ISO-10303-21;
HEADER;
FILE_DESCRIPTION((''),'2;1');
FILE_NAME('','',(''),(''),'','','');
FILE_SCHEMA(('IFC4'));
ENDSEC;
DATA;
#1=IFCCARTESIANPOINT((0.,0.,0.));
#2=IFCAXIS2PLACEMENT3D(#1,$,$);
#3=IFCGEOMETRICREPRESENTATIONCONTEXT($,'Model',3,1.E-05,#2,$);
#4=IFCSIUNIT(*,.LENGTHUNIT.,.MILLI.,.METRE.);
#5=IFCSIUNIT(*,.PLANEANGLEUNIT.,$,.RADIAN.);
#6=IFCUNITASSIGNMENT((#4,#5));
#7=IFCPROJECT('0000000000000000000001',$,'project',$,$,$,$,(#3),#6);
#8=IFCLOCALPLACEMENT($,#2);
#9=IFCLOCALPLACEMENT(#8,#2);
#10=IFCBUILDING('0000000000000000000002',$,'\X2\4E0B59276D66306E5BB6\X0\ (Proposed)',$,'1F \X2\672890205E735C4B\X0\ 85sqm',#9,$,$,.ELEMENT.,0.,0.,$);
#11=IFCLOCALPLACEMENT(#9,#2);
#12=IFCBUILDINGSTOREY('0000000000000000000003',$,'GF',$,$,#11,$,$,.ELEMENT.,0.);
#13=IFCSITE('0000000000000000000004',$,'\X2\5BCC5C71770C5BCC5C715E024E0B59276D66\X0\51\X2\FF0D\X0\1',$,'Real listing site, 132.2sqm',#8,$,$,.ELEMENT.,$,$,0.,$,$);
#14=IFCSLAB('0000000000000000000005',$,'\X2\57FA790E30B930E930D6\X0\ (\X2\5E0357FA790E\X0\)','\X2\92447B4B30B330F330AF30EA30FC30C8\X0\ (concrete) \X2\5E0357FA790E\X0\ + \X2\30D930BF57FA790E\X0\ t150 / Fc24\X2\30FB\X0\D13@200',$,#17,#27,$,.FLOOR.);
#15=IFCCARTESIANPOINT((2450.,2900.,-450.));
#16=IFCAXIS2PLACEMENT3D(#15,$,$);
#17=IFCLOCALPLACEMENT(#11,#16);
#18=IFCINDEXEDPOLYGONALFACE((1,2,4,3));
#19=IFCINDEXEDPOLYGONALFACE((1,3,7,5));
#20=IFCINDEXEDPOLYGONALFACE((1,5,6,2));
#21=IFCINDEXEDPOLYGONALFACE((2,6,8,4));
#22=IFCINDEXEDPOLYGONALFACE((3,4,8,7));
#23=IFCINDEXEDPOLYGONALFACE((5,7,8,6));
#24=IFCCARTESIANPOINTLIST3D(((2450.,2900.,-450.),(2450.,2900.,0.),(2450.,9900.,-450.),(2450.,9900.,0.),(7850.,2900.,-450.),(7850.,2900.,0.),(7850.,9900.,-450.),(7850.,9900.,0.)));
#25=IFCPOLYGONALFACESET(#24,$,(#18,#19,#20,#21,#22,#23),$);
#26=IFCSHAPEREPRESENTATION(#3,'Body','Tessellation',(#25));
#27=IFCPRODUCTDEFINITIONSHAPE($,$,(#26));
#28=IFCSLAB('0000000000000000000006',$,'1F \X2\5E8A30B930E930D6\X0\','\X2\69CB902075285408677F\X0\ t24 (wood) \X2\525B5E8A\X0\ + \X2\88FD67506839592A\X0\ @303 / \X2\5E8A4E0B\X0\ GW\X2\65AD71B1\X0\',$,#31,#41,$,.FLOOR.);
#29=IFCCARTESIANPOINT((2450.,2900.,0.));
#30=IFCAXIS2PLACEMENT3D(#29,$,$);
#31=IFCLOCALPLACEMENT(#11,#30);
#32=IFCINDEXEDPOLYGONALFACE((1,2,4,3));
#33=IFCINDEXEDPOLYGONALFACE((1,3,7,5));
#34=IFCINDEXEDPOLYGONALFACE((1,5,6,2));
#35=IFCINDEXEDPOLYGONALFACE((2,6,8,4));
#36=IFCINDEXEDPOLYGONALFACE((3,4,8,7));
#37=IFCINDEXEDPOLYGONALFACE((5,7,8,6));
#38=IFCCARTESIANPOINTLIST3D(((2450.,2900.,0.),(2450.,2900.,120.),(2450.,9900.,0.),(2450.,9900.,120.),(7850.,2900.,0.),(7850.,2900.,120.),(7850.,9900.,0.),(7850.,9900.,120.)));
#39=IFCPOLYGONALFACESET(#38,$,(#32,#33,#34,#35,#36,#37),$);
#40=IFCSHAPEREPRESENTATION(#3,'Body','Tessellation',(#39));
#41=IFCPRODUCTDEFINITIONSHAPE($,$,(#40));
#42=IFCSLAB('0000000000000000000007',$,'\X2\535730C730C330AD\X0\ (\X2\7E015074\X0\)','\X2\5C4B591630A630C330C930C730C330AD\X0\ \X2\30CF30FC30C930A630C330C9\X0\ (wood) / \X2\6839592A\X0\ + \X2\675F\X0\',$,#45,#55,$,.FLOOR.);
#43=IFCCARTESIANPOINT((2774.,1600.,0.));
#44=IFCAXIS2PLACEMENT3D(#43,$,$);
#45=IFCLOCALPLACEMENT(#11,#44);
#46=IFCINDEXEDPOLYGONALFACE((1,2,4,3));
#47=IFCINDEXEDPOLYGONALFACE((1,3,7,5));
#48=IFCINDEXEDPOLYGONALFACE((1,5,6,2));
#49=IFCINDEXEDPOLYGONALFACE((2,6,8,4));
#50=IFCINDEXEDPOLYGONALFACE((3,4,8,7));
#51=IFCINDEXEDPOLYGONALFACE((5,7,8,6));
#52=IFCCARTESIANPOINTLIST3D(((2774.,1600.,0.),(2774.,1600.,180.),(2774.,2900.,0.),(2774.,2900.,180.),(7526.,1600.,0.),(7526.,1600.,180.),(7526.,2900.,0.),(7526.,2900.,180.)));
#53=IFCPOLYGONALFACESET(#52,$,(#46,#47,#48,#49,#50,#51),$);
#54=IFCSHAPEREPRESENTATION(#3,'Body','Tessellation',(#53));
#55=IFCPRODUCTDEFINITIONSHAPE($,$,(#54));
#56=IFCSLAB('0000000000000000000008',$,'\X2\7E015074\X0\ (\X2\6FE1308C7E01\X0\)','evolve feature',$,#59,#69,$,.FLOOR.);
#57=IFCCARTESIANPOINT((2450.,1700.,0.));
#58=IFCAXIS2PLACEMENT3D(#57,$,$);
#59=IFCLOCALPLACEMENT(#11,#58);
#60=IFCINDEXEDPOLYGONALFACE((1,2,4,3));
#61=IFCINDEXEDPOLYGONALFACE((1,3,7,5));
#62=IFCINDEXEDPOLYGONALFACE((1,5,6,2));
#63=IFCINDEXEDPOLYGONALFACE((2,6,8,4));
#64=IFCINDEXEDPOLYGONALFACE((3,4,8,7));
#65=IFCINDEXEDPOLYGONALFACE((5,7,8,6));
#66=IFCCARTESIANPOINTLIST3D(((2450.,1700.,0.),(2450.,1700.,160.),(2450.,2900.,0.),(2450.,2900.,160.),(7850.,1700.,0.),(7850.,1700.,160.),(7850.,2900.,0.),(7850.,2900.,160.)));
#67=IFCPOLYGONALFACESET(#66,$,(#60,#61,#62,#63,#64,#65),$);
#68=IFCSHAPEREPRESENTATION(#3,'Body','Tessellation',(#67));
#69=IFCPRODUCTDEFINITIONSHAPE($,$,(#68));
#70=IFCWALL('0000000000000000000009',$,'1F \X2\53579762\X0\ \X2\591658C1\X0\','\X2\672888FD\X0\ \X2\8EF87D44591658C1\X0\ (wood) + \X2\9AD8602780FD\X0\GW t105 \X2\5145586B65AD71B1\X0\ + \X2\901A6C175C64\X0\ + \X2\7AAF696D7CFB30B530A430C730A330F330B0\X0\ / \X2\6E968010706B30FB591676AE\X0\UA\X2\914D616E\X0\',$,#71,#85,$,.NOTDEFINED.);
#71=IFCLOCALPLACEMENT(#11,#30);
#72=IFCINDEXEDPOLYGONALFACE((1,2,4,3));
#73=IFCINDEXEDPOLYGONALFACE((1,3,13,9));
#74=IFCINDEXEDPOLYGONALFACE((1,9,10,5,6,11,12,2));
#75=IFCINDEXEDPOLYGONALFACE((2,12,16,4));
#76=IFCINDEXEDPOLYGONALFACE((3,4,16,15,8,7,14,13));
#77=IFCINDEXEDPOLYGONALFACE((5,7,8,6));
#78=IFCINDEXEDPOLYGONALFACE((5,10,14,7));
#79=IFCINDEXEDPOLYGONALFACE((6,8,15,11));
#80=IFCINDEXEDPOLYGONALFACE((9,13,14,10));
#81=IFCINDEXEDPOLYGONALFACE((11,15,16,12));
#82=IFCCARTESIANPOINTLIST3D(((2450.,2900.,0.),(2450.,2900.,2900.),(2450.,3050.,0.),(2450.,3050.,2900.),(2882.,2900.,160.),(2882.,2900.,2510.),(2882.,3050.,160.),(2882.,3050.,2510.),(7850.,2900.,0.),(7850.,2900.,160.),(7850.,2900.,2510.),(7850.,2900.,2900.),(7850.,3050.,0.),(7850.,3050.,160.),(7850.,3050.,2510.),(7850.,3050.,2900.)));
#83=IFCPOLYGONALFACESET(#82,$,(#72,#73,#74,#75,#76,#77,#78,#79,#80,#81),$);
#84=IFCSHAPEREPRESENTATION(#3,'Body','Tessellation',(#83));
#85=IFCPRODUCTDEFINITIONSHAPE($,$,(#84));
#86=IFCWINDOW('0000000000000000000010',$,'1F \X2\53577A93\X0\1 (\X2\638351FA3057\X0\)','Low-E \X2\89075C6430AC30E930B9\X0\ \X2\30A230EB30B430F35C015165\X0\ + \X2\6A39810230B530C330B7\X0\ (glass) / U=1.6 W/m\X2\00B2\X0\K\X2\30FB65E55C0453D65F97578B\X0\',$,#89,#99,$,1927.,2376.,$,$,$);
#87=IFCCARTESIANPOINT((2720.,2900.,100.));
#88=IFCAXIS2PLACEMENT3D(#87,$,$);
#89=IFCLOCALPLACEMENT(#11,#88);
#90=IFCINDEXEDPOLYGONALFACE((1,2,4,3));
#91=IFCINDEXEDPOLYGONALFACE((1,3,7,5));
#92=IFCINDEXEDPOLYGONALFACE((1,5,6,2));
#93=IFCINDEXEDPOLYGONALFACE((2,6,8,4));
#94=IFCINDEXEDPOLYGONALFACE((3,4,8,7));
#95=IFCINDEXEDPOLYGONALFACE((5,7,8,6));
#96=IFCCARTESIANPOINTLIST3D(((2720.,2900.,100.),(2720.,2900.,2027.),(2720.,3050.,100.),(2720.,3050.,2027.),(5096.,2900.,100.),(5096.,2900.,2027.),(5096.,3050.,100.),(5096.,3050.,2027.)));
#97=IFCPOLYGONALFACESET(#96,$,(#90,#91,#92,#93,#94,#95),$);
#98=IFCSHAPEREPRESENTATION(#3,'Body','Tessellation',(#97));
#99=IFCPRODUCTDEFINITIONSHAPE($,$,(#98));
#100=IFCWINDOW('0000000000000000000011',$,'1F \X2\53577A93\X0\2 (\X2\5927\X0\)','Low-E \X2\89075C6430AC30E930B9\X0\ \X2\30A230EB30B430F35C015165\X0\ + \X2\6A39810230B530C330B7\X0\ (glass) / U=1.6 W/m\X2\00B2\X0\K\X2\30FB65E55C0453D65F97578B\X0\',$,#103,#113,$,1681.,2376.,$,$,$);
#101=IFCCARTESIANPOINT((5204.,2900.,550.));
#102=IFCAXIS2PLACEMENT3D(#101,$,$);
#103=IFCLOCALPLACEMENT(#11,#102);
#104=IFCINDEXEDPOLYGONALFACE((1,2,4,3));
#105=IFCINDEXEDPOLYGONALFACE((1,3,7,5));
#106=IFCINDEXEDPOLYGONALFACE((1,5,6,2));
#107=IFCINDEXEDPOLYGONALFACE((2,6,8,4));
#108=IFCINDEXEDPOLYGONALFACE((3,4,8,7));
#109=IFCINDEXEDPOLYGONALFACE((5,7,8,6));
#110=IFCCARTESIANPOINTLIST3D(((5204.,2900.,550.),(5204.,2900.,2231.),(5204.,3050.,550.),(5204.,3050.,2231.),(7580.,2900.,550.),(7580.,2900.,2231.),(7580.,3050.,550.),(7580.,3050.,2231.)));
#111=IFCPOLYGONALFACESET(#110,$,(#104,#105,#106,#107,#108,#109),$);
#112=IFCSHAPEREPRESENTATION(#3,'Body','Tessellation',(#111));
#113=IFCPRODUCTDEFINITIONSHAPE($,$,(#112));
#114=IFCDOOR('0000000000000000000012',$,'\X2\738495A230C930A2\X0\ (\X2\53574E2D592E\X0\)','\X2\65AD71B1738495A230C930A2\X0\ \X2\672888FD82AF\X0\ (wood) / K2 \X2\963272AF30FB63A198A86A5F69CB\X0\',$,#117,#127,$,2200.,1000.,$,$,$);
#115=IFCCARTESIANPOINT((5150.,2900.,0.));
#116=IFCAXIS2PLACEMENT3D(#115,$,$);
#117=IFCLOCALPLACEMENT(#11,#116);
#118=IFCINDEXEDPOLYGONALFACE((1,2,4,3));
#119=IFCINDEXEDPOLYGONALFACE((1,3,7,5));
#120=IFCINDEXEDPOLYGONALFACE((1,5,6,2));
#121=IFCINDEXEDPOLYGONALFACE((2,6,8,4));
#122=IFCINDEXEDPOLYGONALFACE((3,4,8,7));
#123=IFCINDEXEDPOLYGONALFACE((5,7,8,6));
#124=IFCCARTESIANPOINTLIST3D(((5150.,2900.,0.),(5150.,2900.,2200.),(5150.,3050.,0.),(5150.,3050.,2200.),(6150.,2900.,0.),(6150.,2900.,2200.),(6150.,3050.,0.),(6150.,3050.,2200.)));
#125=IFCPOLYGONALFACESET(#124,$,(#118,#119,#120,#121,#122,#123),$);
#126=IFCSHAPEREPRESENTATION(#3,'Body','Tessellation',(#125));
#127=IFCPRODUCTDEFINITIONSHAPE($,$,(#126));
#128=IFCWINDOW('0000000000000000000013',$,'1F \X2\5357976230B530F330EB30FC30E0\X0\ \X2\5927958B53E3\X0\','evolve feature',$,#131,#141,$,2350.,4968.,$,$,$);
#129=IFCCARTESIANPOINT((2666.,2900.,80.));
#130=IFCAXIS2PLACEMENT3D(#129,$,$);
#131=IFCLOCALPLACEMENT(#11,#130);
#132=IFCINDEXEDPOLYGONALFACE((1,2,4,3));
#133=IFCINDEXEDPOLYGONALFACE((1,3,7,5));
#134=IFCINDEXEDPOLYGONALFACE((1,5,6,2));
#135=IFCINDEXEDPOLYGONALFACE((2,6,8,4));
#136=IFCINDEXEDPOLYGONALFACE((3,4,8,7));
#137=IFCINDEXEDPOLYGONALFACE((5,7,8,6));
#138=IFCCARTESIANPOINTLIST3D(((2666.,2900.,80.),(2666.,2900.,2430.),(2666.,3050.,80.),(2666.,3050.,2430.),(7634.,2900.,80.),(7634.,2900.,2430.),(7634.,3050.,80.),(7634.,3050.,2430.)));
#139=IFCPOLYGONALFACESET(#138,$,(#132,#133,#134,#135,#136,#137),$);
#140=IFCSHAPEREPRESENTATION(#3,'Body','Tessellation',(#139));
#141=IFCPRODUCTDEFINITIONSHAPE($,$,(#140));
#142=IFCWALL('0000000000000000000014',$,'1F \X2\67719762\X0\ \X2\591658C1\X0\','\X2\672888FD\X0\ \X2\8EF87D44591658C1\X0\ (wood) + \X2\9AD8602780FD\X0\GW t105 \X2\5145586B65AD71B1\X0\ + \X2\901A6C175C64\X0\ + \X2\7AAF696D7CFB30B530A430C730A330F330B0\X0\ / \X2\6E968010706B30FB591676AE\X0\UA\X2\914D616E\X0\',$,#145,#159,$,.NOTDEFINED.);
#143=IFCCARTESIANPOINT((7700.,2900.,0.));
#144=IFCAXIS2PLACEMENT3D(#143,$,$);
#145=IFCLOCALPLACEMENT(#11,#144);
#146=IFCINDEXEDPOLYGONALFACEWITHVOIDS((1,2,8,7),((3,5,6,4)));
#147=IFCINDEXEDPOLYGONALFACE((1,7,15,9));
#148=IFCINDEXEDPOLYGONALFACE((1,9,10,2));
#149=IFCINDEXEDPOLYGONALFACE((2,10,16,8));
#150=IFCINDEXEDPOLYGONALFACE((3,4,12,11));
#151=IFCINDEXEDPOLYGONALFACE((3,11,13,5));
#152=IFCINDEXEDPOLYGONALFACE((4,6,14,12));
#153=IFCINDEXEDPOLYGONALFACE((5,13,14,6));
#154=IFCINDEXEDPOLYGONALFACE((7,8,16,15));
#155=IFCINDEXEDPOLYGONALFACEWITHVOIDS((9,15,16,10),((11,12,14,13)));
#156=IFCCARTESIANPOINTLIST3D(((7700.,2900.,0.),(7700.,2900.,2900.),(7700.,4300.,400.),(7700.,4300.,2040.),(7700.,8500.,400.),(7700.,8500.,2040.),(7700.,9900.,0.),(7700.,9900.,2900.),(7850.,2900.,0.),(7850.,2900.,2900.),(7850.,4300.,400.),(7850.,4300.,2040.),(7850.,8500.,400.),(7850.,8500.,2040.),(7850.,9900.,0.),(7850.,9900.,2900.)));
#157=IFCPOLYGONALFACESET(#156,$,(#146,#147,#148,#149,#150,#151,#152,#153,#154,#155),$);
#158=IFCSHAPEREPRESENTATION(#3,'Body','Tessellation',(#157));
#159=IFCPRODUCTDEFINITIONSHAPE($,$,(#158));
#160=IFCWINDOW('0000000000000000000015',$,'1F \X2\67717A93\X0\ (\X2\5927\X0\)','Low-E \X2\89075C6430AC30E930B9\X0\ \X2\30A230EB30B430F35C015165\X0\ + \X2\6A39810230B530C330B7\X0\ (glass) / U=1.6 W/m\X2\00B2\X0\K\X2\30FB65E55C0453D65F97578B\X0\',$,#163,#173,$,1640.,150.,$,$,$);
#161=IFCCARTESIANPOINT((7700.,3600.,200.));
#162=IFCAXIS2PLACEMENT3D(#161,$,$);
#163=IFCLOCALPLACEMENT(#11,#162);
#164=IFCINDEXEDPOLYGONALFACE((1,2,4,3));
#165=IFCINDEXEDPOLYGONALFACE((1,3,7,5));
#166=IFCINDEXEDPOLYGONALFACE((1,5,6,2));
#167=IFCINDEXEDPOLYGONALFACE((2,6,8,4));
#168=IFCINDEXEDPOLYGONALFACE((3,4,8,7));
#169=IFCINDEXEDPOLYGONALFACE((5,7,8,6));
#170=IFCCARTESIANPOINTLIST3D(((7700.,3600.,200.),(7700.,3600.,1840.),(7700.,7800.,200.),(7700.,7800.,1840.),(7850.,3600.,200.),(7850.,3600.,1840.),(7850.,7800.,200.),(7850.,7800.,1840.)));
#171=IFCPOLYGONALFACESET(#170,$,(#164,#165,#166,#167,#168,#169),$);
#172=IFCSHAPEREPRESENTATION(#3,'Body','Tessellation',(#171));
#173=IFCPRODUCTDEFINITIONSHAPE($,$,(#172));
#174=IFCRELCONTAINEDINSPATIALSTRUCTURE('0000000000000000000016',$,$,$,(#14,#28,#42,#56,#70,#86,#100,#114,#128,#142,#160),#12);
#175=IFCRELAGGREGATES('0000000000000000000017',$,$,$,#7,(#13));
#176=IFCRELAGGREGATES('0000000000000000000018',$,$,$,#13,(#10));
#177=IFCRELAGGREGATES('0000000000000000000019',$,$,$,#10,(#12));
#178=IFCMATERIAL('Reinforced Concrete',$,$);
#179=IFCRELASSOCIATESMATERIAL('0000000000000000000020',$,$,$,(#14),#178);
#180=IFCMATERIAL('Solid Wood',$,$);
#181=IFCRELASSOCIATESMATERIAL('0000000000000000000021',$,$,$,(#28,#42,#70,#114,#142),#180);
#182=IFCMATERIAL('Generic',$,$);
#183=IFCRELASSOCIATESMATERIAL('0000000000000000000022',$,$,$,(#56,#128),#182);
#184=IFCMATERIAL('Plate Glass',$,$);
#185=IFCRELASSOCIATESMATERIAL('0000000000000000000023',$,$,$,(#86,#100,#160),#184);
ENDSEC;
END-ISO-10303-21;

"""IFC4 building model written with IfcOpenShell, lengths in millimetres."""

from ifc_helpers import new_model, si_unit, frame, frame_2d, origin, place, context, project, spatial, rectangle, extrude, material, element, fill, save


model = new_model("IFC4")

# Units and contexts
model_context = context("Model", 3, precision=1e-05, world=origin())
ifc_project = project(units=[si_unit("LENGTHUNIT", "METRE", prefix="MILLI"), si_unit("PLANEANGLEUNIT", "RADIAN")], contexts=[model_context])

# Site, building, storey
site_placement = place(None, origin())
site = spatial("IfcSite", under=ifc_project, at=site_placement, Name="富山県富山市下大浦51－1", ObjectType="Real listing site, 132.2sqm", CompositionType="ELEMENT", RefElevation=0.0)
building_placement = place(site_placement, origin())
building = spatial("IfcBuilding", under=site, at=building_placement, Name="下大浦の家 (Proposed)", ObjectType="1F 木造平屋 85sqm", CompositionType="ELEMENT", ElevationOfRefHeight=0.0, ElevationOfTerrain=0.0)
storey_placement = place(building_placement, origin())
storey = spatial("IfcBuildingStorey", under=building, at=storey_placement, Name="GF", CompositionType="ELEMENT", Elevation=0.0)

# Slabs
ifc_material_1 = material(Name="Reinforced Concrete")
slab_1_placement = place(storey_placement, frame((2450.0, 2900.0, -450.0)))
element("IfcSlab", 1, at=slab_1_placement, inside=storey, material=ifc_material_1, Name="基礎スラブ (布基礎)", Description="鉄筋コンクリート (concrete) 布基礎 + ベタ基礎 t150 / Fc24・D13@200", PredefinedType="FLOOR", context=model_context, shape_type="SweptSolid", body=[
    extrude(rectangle(XDim=5400.0, YDim=7000.0, at=frame_2d((2700.0, 3500.0))), frame((2450.0, 2900.0, -450.0)), (0.0, 0.0, 1.0), 450.0),
])
ifc_material_2 = material(Name="Solid Wood")
slab_2_placement = place(storey_placement, frame((2450.0, 2900.0, 0.0)))
element("IfcSlab", 2, at=slab_2_placement, inside=storey, material=ifc_material_2, Name="1F 床スラブ", Description="構造用合板 t24 (wood) 剛床 + 製材根太 @303 / 床下 GW断熱", PredefinedType="FLOOR", context=model_context, shape_type="SweptSolid", body=[
    extrude(rectangle(XDim=5400.0, YDim=7000.0, at=frame_2d((2700.0, 3500.0))), frame((2450.0, 2900.0, 0.0)), (0.0, 0.0, 1.0), 120.0),
])
slab_3_placement = place(storey_placement, frame((2774.0, 1600.0, 0.0)))
element("IfcSlab", 3, at=slab_3_placement, inside=storey, material=ifc_material_2, Name="南デッキ (縁側)", Description="屋外ウッドデッキ ハードウッド (wood) / 根太 + 束", PredefinedType="FLOOR", context=model_context, shape_type="SweptSolid", body=[
    extrude(rectangle(XDim=4752.0, YDim=1300.0, at=frame_2d((2376.0, 650.0))), frame((2774.0, 1600.0, 0.0)), (0.0, 0.0, 1.0), 180.0),
])
ifc_material_3 = material(Name="Generic")
slab_4_placement = place(storey_placement, frame((2450.0, 1700.0, 0.0)))
element("IfcSlab", 4, at=slab_4_placement, inside=storey, material=ifc_material_3, Name="縁側 (濡れ縁)", Description="evolve feature", PredefinedType="FLOOR", context=model_context, shape_type="SweptSolid", body=[
    extrude(rectangle(XDim=5400.0, YDim=1200.0, at=frame_2d((2700.0, 600.0))), frame((2450.0, 1700.0, 0.0)), (0.0, 0.0, 1.0), 160.0),
])

# Wall, openings, windows, door
wall_1_placement = place(storey_placement, frame((2450.0, 2900.0, 0.0)))
wall_1 = element("IfcWall", 5, at=wall_1_placement, inside=storey, material=ifc_material_2, Name="1F 南面 外壁", Description="木製 軸組外壁 (wood) + 高性能GW t105 充填断熱 + 通気層 + 窯業系サイディング / 準耐火・外皮UA配慮", PredefinedType="NOTDEFINED", context=model_context, shape_type="SweptSolid", body=[
    extrude(rectangle(XDim=5400.0, YDim=150.0, at=frame_2d((2700.0, 75.0))), frame((2450.0, 2900.0, 0.0)), (0.0, 0.0, 1.0), 2900.0),
])
opening_1_placement = place(storey_placement, frame((2720.0, 2900.0, 100.0)))
opening_1 = element("IfcOpeningElement", 6, at=opening_1_placement, cuts=wall_1, PredefinedType="NOTDEFINED", context=model_context, shape_type="SweptSolid", body=[
    extrude(rectangle(XDim=2376.0, YDim=150.0, at=frame_2d((1188.0, 75.0))), frame((2720.0, 2900.0, 100.0)), (0.0, 0.0, 1.0), 1927.0),
])
opening_2_placement = place(storey_placement, frame((5204.0, 2900.0, 550.0)))
opening_2 = element("IfcOpeningElement", 7, at=opening_2_placement, cuts=wall_1, PredefinedType="NOTDEFINED", context=model_context, shape_type="SweptSolid", body=[
    extrude(rectangle(XDim=2376.0, YDim=150.0, at=frame_2d((1188.0, 75.0))), frame((5204.0, 2900.0, 550.0)), (0.0, 0.0, 1.0), 1681.0),
])
opening_3_placement = place(storey_placement, frame((5150.0, 2900.0, 0.0)))
opening_3 = element("IfcOpeningElement", 8, at=opening_3_placement, cuts=wall_1, PredefinedType="NOTDEFINED", context=model_context, shape_type="SweptSolid", body=[
    extrude(rectangle(XDim=1000.0, YDim=150.0, at=frame_2d((500.0, 75.0))), frame((5150.0, 2900.0, 0.0)), (0.0, 0.0, 1.0), 2200.0),
])
opening_4_placement = place(storey_placement, frame((2666.0, 2900.0, 80.0)))
opening_4 = element("IfcOpeningElement", 9, at=opening_4_placement, cuts=wall_1, PredefinedType="NOTDEFINED", context=model_context, shape_type="SweptSolid", body=[
    extrude(rectangle(XDim=4968.0, YDim=150.0, at=frame_2d((2484.0, 75.0))), frame((2666.0, 2900.0, 80.0)), (0.0, 0.0, 1.0), 2350.0),
])
ifc_material_4 = material(Name="Plate Glass")
window_1_placement = place(storey_placement, frame((2720.0, 2900.0, 100.0)))
window_1 = element("IfcWindow", 10, at=window_1_placement, inside=storey, material=ifc_material_4, Name="1F 南窓1 (掃出し)", Description="Low-E 複層ガラス アルゴン封入 + 樹脂サッシ (glass) / U=1.6 W/m²K・日射取得型", OverallHeight=1927.0, OverallWidth=2376.0, context=model_context, shape_type="SweptSolid", body=[
    extrude(rectangle(XDim=2376.0, YDim=150.0, at=frame_2d((1188.0, 75.0))), frame((2720.0, 2900.0, 100.0)), (0.0, 0.0, 1.0), 1927.0),
])
fill(opening_1, window_1)
window_2_placement = place(storey_placement, frame((5204.0, 2900.0, 550.0)))
window_2 = element("IfcWindow", 11, at=window_2_placement, inside=storey, material=ifc_material_4, Name="1F 南窓2 (大)", Description="Low-E 複層ガラス アルゴン封入 + 樹脂サッシ (glass) / U=1.6 W/m²K・日射取得型", OverallHeight=1681.0, OverallWidth=2376.0, context=model_context, shape_type="SweptSolid", body=[
    extrude(rectangle(XDim=2376.0, YDim=150.0, at=frame_2d((1188.0, 75.0))), frame((5204.0, 2900.0, 550.0)), (0.0, 0.0, 1.0), 1681.0),
])
fill(opening_2, window_2)
door_placement = place(storey_placement, frame((5150.0, 2900.0, 0.0)))
door = element("IfcDoor", 12, at=door_placement, inside=storey, material=ifc_material_2, Name="玄関ドア (南中央)", Description="断熱玄関ドア 木製芯 (wood) / K2 防犯・採風機構", OverallHeight=2200.0, OverallWidth=1000.0, context=model_context, shape_type="SweptSolid", body=[
    extrude(rectangle(XDim=1000.0, YDim=150.0, at=frame_2d((500.0, 75.0))), frame((5150.0, 2900.0, 0.0)), (0.0, 0.0, 1.0), 2200.0),
])
fill(opening_3, door)
window_3_placement = place(storey_placement, frame((2666.0, 2900.0, 80.0)))
window_3 = element("IfcWindow", 13, at=window_3_placement, inside=storey, material=ifc_material_3, Name="1F 南面サンルーム 大開口", Description="evolve feature", OverallHeight=2350.0, OverallWidth=4968.0, context=model_context, shape_type="SweptSolid", body=[
    extrude(rectangle(XDim=4968.0, YDim=150.0, at=frame_2d((2484.0, 75.0))), frame((2666.0, 2900.0, 80.0)), (0.0, 0.0, 1.0), 2350.0),
])
fill(opening_4, window_3)

# Wall, opening, window
wall_2_placement = place(storey_placement, frame((7700.0, 2900.0, 0.0)))
wall_2 = element("IfcWall", 14, at=wall_2_placement, inside=storey, material=ifc_material_2, Name="1F 東面 外壁", Description="木製 軸組外壁 (wood) + 高性能GW t105 充填断熱 + 通気層 + 窯業系サイディング / 準耐火・外皮UA配慮", PredefinedType="NOTDEFINED", context=model_context, shape_type="SweptSolid", body=[
    extrude(rectangle(XDim=150.0, YDim=7000.0, at=frame_2d((75.0, 3500.0))), frame((7700.0, 2900.0, 0.0)), (0.0, 0.0, 1.0), 2900.0),
])
opening_5_placement = place(storey_placement, frame((7700.0, 3600.0, 200.0)))
opening_5 = element("IfcOpeningElement", 15, at=opening_5_placement, cuts=wall_2, PredefinedType="NOTDEFINED", context=model_context, shape_type="SweptSolid", body=[
    extrude(rectangle(XDim=150.0, YDim=4200.0, at=frame_2d((75.0, 2100.0))), frame((7700.0, 3600.0, 200.0)), (0.0, 0.0, 1.0), 1640.0),
])
window_4_placement = place(storey_placement, frame((7700.0, 3600.0, 200.0)))
window_4 = element("IfcWindow", 16, at=window_4_placement, inside=storey, material=ifc_material_4, Name="1F 東窓 (大)", Description="Low-E 複層ガラス アルゴン封入 + 樹脂サッシ (glass) / U=1.6 W/m²K・日射取得型", OverallHeight=1640.0, OverallWidth=150.0, context=model_context, shape_type="SweptSolid", body=[
    extrude(rectangle(XDim=150.0, YDim=4200.0, at=frame_2d((75.0, 2100.0))), frame((7700.0, 3600.0, 200.0)), (0.0, 0.0, 1.0), 1640.0),
])
fill(opening_5, window_4)

save(model, "model.ifc")
